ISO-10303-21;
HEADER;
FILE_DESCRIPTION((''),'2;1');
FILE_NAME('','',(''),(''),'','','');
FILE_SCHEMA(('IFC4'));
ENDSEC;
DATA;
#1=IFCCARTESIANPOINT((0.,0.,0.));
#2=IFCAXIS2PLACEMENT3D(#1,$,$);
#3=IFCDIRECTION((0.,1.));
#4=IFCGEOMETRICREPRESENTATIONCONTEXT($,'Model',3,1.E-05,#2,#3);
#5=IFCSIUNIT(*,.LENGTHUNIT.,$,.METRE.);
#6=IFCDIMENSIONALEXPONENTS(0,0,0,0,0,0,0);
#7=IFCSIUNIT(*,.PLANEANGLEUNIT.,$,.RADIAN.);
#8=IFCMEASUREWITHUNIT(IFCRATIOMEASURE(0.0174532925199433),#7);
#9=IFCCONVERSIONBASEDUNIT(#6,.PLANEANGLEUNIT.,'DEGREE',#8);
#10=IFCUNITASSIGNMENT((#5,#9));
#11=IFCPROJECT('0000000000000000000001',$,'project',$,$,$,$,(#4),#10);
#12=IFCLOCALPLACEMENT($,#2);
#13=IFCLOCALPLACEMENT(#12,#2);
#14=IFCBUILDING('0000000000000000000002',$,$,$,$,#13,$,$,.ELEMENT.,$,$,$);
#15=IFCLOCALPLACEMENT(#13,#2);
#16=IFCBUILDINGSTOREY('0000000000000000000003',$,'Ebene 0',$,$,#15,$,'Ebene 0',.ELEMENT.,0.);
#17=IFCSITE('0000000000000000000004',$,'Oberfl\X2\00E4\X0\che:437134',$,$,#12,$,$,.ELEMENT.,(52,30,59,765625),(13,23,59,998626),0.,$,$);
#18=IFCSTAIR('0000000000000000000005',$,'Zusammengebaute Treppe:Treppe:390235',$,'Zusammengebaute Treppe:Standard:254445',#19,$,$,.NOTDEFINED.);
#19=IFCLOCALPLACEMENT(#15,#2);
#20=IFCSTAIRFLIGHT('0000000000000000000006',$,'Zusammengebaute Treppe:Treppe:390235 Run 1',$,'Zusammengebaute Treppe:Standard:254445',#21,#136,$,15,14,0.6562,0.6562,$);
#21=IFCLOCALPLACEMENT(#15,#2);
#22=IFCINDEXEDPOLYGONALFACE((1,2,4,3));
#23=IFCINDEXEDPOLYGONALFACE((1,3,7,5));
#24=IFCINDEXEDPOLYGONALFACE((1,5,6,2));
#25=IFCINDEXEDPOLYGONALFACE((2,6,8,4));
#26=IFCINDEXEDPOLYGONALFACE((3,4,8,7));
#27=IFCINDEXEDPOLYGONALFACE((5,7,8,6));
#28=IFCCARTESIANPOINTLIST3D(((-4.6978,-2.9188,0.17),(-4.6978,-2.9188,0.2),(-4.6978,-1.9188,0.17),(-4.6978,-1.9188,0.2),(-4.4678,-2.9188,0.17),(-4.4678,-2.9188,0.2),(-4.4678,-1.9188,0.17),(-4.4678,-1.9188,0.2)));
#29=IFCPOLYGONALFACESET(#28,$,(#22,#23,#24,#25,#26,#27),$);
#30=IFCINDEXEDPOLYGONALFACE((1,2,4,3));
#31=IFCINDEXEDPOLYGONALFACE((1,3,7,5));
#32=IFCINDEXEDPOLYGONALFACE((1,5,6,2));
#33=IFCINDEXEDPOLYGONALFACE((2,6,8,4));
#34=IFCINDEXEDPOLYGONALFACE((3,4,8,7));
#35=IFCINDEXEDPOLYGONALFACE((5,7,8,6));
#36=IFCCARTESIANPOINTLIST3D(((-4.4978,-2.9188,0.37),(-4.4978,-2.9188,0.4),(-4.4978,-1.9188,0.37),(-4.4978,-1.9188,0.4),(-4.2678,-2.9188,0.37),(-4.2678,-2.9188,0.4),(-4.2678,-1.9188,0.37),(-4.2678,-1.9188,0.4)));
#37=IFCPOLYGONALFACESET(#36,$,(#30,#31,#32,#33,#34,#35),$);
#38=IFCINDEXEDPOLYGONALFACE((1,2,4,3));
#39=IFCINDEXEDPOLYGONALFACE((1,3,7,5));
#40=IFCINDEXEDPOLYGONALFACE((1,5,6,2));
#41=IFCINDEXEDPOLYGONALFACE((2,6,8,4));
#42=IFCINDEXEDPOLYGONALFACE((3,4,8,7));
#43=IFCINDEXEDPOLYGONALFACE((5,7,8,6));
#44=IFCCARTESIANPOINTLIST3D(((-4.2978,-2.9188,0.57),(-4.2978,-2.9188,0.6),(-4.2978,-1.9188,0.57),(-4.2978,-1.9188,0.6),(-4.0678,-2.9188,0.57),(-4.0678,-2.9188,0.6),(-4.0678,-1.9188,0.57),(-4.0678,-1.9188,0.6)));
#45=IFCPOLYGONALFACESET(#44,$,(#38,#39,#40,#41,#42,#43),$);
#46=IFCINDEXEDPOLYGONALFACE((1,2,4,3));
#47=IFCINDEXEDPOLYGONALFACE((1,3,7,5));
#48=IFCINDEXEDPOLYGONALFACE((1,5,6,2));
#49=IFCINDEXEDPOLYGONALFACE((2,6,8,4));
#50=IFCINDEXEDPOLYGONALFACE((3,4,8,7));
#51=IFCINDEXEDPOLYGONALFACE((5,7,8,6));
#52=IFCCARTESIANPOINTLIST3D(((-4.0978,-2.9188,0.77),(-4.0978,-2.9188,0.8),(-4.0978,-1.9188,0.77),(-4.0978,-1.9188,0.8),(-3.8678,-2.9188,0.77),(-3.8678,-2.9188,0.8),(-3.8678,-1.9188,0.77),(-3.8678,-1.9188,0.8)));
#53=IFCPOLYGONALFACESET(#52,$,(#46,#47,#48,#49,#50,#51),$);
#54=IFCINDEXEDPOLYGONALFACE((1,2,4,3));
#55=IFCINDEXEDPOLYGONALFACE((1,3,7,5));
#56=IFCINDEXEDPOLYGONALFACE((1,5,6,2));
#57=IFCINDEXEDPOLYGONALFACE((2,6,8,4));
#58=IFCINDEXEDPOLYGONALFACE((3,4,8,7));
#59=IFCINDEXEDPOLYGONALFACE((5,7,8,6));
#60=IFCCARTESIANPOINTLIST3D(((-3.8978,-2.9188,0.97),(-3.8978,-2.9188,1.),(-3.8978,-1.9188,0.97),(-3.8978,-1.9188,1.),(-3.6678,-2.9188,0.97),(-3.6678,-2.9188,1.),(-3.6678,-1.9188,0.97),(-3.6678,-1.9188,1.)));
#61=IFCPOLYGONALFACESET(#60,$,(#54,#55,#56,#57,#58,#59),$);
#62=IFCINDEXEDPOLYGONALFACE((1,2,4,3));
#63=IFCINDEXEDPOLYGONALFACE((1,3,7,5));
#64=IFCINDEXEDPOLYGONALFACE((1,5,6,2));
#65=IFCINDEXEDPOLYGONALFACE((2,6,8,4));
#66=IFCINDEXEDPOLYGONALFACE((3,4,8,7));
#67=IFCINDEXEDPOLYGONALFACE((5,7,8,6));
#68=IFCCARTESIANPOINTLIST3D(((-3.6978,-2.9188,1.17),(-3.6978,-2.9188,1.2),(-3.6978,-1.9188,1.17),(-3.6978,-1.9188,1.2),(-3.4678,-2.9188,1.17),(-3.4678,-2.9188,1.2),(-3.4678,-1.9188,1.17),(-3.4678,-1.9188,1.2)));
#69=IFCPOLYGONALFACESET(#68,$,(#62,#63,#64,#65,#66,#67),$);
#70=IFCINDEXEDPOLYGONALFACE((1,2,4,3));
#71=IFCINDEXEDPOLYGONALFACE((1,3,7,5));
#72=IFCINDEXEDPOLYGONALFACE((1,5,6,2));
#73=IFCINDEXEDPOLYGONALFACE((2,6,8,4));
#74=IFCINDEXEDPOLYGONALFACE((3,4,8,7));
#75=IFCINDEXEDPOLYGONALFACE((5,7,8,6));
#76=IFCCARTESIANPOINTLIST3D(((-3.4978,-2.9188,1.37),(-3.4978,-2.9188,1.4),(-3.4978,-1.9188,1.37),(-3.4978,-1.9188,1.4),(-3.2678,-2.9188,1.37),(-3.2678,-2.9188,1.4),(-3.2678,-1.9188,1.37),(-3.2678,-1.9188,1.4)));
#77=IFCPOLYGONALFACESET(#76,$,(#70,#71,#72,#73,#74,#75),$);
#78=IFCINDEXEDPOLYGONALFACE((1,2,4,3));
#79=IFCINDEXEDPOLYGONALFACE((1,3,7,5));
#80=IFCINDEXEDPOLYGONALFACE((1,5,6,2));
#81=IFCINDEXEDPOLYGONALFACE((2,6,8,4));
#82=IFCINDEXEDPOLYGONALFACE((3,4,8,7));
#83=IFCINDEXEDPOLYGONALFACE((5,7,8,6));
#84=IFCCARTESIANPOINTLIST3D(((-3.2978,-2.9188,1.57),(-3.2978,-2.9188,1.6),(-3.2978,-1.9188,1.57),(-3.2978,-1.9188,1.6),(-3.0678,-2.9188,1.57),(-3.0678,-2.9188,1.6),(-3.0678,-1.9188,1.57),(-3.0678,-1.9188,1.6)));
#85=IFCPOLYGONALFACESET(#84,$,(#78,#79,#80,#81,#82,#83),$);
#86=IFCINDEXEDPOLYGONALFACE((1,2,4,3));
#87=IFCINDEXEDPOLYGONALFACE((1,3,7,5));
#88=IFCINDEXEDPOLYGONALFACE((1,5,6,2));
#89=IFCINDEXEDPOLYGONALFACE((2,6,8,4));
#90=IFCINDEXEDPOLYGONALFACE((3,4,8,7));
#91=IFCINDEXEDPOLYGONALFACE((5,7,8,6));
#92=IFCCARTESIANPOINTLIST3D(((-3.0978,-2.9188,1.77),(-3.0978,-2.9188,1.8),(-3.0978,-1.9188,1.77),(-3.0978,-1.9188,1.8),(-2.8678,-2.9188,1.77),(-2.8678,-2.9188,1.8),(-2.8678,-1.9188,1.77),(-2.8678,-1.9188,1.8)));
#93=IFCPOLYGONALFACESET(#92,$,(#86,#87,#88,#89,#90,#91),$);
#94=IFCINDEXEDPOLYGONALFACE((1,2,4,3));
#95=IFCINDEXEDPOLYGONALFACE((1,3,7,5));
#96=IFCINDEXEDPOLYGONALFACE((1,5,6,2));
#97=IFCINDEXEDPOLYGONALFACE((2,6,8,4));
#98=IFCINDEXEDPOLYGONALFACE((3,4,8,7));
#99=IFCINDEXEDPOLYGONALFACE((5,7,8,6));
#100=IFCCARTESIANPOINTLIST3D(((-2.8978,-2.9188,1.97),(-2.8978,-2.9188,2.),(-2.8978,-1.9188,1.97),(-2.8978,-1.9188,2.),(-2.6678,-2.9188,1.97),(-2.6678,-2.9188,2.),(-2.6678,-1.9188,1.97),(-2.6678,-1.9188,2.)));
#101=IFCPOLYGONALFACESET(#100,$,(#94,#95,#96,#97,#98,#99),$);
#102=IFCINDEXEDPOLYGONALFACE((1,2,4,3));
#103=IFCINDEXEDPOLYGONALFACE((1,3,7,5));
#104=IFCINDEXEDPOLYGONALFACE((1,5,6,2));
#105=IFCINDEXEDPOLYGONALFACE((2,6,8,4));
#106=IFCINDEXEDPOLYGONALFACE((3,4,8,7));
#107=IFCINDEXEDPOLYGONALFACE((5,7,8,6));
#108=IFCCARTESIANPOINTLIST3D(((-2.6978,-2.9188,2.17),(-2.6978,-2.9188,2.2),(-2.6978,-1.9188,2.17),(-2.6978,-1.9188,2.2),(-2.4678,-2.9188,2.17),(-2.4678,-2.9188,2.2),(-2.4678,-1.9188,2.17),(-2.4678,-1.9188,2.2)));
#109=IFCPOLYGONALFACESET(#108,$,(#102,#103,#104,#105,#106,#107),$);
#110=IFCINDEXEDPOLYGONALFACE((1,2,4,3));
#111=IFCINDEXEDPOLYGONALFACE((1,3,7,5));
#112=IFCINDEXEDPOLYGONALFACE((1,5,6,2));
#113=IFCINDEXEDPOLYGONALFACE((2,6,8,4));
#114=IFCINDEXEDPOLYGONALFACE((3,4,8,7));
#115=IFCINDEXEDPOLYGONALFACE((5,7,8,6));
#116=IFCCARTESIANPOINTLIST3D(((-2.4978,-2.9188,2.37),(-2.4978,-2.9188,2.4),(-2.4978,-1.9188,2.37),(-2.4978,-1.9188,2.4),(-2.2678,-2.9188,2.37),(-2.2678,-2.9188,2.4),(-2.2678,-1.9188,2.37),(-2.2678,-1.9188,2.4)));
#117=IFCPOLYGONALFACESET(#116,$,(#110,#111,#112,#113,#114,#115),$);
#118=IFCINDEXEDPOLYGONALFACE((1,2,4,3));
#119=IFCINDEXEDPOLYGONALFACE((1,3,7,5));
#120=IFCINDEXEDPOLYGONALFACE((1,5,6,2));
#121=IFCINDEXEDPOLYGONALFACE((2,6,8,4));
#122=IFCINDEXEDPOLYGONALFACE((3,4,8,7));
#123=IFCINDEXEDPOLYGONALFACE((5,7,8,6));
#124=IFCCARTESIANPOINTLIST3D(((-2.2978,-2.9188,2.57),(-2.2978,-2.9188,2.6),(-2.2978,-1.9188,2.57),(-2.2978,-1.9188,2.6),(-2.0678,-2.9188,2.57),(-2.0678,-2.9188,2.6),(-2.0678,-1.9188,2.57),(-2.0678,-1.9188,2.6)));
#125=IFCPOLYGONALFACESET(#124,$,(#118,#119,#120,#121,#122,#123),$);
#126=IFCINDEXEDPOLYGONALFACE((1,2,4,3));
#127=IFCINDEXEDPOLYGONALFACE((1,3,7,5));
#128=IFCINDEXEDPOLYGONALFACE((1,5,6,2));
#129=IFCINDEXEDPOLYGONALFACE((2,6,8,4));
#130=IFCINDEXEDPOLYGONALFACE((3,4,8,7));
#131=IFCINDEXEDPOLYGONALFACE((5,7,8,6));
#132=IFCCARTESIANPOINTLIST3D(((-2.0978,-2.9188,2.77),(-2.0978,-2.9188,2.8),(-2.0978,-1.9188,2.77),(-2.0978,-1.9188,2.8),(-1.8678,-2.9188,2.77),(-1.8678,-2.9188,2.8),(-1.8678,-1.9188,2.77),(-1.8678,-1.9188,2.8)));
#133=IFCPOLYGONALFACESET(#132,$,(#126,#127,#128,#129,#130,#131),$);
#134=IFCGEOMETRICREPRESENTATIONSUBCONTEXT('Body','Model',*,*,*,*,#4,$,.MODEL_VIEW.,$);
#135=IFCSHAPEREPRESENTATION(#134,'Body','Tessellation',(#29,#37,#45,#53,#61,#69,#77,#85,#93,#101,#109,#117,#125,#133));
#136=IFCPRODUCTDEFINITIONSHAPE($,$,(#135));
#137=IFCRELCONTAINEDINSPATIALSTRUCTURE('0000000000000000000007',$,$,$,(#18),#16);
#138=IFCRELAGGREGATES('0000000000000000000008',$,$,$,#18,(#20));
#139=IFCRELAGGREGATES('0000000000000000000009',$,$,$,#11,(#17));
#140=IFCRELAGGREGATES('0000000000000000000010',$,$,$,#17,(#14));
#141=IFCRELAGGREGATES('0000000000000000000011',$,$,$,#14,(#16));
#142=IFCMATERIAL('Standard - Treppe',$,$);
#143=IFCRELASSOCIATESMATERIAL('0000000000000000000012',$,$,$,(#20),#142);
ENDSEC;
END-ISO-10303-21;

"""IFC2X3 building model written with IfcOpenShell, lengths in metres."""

from ifc_helpers import new_model, entity, si_unit, converted_unit, direction, frame, frame_2d, origin, place, context, subcontext, project, spatial, rectangle, extrude, material, element, aggregate, save


model = new_model("IFC2X3")

# Units and contexts
model_context = context("Model", 3, precision=1e-05, world=origin(), true_north=direction((0.0, 1.0)))
body_context = subcontext(model_context, "Body", "Model", "MODEL_VIEW")
ifc_project = project(units=[si_unit("LENGTHUNIT", "METRE"), converted_unit("PLANEANGLEUNIT", "DEGREE", entity("IfcRatioMeasure", 0.0174532925199433), si_unit("PLANEANGLEUNIT", "RADIAN"), dimensions=[0, 0, 0, 0, 0, 0, 0])], contexts=[model_context])

# Site, building, storey
site_placement = place(None, origin())
site = spatial("IfcSite", under=ifc_project, at=site_placement, Name="Oberfläche:437134", CompositionType="ELEMENT", RefLatitude=(52, 30, 59, 765625), RefLongitude=(13, 23, 59, 998626), RefElevation=0.0)
building_placement = place(site_placement, origin())
building = spatial("IfcBuilding", under=site, at=building_placement, CompositionType="ELEMENT")
storey_placement = place(building_placement, origin())
storey = spatial("IfcBuildingStorey", under=building, at=storey_placement, Name="Ebene 0", LongName="Ebene 0", CompositionType="ELEMENT", Elevation=0.0)

# Stair, stair flight
stair_1_placement = place(storey_placement, origin())
stair_1 = element("IfcStair", 1, at=stair_1_placement, inside=storey, Name="Zusammengebaute Treppe:Treppe:390235", ObjectType="Zusammengebaute Treppe:Standard:254445", ShapeType="NOTDEFINED")
ifc_material_1 = material(Name="Standard - Treppe")
stair_flight_1_placement = place(stair_1_placement, origin())
stair_flight_1 = element("IfcStairFlight", 2, at=stair_flight_1_placement, material=ifc_material_1, Name="Zusammengebaute Treppe:Treppe:390235 Run 1", ObjectType="Zusammengebaute Treppe:Standard:254445", NumberOfRiser=15, NumberOfTreads=14, RiserHeight=0.6562, TreadLength=0.6562, context=body_context, shape_type="SweptSolid", body=[
    extrude(rectangle(XDim=0.23, YDim=1.0, at=frame_2d((0.0, 0.0), x_axis=(1.0, 0.0))), frame((-4.5828, -2.4188, 0.17), z_axis=(0.0, 0.0, 1.0), x_axis=(-1.0, 0.0, 0.0)), (0.0, 0.0, 1.0), 0.03),
    extrude(rectangle(XDim=0.23, YDim=1.0, at=frame_2d((0.0, 0.0), x_axis=(1.0, 0.0))), frame((-4.3828, -2.4188, 0.37), z_axis=(0.0, 0.0, 1.0), x_axis=(-1.0, 0.0, 0.0)), (0.0, 0.0, 1.0), 0.03),
    extrude(rectangle(XDim=0.23, YDim=1.0, at=frame_2d((0.0, 0.0), x_axis=(1.0, 0.0))), frame((-4.1828, -2.4188, 0.57), z_axis=(0.0, 0.0, 1.0), x_axis=(-1.0, 0.0, 0.0)), (0.0, 0.0, 1.0), 0.03),
    extrude(rectangle(XDim=0.23, YDim=1.0, at=frame_2d((0.0, 0.0), x_axis=(1.0, 0.0))), frame((-3.9828, -2.4188, 0.77), z_axis=(0.0, 0.0, 1.0), x_axis=(-1.0, 0.0, 0.0)), (0.0, 0.0, 1.0), 0.03),
    extrude(rectangle(XDim=0.23, YDim=1.0, at=frame_2d((0.0, 0.0), x_axis=(1.0, 0.0))), frame((-3.7828, -2.4188, 0.97), z_axis=(0.0, 0.0, 1.0), x_axis=(-1.0, 0.0, 0.0)), (0.0, 0.0, 1.0), 0.03),
    extrude(rectangle(XDim=0.23, YDim=1.0, at=frame_2d((0.0, 0.0), x_axis=(1.0, 0.0))), frame((-3.5828, -2.4188, 1.17), z_axis=(0.0, 0.0, 1.0), x_axis=(-1.0, 0.0, 0.0)), (0.0, 0.0, 1.0), 0.03),
    extrude(rectangle(XDim=0.23, YDim=1.0, at=frame_2d((0.0, 0.0), x_axis=(1.0, 0.0))), frame((-3.3828, -2.4188, 1.37), z_axis=(0.0, 0.0, 1.0), x_axis=(-1.0, 0.0, 0.0)), (0.0, 0.0, 1.0), 0.03),
    extrude(rectangle(XDim=0.23, YDim=1.0, at=frame_2d((0.0, 0.0), x_axis=(1.0, 0.0))), frame((-3.1828, -2.4188, 1.57), z_axis=(0.0, 0.0, 1.0), x_axis=(-1.0, 0.0, 0.0)), (0.0, 0.0, 1.0), 0.03),
    extrude(rectangle(XDim=0.23, YDim=1.0, at=frame_2d((0.0, 0.0), x_axis=(1.0, 0.0))), frame((-2.9828, -2.4188, 1.77), z_axis=(0.0, 0.0, 1.0), x_axis=(-1.0, 0.0, 0.0)), (0.0, 0.0, 1.0), 0.03),
    extrude(rectangle(XDim=0.23, YDim=1.0, at=frame_2d((0.0, 0.0), x_axis=(1.0, 0.0))), frame((-2.7828, -2.4188, 1.97), z_axis=(0.0, 0.0, 1.0), x_axis=(-1.0, 0.0, 0.0)), (0.0, 0.0, 1.0), 0.03),
    extrude(rectangle(XDim=0.23, YDim=1.0, at=frame_2d((0.0, 0.0), x_axis=(1.0, 0.0))), frame((-2.5828, -2.4188, 2.17), z_axis=(0.0, 0.0, 1.0), x_axis=(-1.0, 0.0, 0.0)), (0.0, 0.0, 1.0), 0.03),
    extrude(rectangle(XDim=0.23, YDim=1.0, at=frame_2d((0.0, 0.0), x_axis=(1.0, 0.0))), frame((-2.3828, -2.4188, 2.37), z_axis=(0.0, 0.0, 1.0), x_axis=(-1.0, 0.0, 0.0)), (0.0, 0.0, 1.0), 0.03),
    extrude(rectangle(XDim=0.23, YDim=1.0, at=frame_2d((0.0, 0.0), x_axis=(1.0, 0.0))), frame((-2.1828, -2.4188, 2.57), z_axis=(0.0, 0.0, 1.0), x_axis=(-1.0, 0.0, 0.0)), (0.0, 0.0, 1.0), 0.03),
    extrude(rectangle(XDim=0.23, YDim=1.0, at=frame_2d((0.0, 0.0), x_axis=(1.0, 0.0))), frame((-1.9828, -2.4188, 2.77), z_axis=(0.0, 0.0, 1.0), x_axis=(-1.0, 0.0, 0.0)), (0.0, 0.0, 1.0), 0.03),
])
aggregate(stair_1, [stair_flight_1])

save(model, "model.ifc")
